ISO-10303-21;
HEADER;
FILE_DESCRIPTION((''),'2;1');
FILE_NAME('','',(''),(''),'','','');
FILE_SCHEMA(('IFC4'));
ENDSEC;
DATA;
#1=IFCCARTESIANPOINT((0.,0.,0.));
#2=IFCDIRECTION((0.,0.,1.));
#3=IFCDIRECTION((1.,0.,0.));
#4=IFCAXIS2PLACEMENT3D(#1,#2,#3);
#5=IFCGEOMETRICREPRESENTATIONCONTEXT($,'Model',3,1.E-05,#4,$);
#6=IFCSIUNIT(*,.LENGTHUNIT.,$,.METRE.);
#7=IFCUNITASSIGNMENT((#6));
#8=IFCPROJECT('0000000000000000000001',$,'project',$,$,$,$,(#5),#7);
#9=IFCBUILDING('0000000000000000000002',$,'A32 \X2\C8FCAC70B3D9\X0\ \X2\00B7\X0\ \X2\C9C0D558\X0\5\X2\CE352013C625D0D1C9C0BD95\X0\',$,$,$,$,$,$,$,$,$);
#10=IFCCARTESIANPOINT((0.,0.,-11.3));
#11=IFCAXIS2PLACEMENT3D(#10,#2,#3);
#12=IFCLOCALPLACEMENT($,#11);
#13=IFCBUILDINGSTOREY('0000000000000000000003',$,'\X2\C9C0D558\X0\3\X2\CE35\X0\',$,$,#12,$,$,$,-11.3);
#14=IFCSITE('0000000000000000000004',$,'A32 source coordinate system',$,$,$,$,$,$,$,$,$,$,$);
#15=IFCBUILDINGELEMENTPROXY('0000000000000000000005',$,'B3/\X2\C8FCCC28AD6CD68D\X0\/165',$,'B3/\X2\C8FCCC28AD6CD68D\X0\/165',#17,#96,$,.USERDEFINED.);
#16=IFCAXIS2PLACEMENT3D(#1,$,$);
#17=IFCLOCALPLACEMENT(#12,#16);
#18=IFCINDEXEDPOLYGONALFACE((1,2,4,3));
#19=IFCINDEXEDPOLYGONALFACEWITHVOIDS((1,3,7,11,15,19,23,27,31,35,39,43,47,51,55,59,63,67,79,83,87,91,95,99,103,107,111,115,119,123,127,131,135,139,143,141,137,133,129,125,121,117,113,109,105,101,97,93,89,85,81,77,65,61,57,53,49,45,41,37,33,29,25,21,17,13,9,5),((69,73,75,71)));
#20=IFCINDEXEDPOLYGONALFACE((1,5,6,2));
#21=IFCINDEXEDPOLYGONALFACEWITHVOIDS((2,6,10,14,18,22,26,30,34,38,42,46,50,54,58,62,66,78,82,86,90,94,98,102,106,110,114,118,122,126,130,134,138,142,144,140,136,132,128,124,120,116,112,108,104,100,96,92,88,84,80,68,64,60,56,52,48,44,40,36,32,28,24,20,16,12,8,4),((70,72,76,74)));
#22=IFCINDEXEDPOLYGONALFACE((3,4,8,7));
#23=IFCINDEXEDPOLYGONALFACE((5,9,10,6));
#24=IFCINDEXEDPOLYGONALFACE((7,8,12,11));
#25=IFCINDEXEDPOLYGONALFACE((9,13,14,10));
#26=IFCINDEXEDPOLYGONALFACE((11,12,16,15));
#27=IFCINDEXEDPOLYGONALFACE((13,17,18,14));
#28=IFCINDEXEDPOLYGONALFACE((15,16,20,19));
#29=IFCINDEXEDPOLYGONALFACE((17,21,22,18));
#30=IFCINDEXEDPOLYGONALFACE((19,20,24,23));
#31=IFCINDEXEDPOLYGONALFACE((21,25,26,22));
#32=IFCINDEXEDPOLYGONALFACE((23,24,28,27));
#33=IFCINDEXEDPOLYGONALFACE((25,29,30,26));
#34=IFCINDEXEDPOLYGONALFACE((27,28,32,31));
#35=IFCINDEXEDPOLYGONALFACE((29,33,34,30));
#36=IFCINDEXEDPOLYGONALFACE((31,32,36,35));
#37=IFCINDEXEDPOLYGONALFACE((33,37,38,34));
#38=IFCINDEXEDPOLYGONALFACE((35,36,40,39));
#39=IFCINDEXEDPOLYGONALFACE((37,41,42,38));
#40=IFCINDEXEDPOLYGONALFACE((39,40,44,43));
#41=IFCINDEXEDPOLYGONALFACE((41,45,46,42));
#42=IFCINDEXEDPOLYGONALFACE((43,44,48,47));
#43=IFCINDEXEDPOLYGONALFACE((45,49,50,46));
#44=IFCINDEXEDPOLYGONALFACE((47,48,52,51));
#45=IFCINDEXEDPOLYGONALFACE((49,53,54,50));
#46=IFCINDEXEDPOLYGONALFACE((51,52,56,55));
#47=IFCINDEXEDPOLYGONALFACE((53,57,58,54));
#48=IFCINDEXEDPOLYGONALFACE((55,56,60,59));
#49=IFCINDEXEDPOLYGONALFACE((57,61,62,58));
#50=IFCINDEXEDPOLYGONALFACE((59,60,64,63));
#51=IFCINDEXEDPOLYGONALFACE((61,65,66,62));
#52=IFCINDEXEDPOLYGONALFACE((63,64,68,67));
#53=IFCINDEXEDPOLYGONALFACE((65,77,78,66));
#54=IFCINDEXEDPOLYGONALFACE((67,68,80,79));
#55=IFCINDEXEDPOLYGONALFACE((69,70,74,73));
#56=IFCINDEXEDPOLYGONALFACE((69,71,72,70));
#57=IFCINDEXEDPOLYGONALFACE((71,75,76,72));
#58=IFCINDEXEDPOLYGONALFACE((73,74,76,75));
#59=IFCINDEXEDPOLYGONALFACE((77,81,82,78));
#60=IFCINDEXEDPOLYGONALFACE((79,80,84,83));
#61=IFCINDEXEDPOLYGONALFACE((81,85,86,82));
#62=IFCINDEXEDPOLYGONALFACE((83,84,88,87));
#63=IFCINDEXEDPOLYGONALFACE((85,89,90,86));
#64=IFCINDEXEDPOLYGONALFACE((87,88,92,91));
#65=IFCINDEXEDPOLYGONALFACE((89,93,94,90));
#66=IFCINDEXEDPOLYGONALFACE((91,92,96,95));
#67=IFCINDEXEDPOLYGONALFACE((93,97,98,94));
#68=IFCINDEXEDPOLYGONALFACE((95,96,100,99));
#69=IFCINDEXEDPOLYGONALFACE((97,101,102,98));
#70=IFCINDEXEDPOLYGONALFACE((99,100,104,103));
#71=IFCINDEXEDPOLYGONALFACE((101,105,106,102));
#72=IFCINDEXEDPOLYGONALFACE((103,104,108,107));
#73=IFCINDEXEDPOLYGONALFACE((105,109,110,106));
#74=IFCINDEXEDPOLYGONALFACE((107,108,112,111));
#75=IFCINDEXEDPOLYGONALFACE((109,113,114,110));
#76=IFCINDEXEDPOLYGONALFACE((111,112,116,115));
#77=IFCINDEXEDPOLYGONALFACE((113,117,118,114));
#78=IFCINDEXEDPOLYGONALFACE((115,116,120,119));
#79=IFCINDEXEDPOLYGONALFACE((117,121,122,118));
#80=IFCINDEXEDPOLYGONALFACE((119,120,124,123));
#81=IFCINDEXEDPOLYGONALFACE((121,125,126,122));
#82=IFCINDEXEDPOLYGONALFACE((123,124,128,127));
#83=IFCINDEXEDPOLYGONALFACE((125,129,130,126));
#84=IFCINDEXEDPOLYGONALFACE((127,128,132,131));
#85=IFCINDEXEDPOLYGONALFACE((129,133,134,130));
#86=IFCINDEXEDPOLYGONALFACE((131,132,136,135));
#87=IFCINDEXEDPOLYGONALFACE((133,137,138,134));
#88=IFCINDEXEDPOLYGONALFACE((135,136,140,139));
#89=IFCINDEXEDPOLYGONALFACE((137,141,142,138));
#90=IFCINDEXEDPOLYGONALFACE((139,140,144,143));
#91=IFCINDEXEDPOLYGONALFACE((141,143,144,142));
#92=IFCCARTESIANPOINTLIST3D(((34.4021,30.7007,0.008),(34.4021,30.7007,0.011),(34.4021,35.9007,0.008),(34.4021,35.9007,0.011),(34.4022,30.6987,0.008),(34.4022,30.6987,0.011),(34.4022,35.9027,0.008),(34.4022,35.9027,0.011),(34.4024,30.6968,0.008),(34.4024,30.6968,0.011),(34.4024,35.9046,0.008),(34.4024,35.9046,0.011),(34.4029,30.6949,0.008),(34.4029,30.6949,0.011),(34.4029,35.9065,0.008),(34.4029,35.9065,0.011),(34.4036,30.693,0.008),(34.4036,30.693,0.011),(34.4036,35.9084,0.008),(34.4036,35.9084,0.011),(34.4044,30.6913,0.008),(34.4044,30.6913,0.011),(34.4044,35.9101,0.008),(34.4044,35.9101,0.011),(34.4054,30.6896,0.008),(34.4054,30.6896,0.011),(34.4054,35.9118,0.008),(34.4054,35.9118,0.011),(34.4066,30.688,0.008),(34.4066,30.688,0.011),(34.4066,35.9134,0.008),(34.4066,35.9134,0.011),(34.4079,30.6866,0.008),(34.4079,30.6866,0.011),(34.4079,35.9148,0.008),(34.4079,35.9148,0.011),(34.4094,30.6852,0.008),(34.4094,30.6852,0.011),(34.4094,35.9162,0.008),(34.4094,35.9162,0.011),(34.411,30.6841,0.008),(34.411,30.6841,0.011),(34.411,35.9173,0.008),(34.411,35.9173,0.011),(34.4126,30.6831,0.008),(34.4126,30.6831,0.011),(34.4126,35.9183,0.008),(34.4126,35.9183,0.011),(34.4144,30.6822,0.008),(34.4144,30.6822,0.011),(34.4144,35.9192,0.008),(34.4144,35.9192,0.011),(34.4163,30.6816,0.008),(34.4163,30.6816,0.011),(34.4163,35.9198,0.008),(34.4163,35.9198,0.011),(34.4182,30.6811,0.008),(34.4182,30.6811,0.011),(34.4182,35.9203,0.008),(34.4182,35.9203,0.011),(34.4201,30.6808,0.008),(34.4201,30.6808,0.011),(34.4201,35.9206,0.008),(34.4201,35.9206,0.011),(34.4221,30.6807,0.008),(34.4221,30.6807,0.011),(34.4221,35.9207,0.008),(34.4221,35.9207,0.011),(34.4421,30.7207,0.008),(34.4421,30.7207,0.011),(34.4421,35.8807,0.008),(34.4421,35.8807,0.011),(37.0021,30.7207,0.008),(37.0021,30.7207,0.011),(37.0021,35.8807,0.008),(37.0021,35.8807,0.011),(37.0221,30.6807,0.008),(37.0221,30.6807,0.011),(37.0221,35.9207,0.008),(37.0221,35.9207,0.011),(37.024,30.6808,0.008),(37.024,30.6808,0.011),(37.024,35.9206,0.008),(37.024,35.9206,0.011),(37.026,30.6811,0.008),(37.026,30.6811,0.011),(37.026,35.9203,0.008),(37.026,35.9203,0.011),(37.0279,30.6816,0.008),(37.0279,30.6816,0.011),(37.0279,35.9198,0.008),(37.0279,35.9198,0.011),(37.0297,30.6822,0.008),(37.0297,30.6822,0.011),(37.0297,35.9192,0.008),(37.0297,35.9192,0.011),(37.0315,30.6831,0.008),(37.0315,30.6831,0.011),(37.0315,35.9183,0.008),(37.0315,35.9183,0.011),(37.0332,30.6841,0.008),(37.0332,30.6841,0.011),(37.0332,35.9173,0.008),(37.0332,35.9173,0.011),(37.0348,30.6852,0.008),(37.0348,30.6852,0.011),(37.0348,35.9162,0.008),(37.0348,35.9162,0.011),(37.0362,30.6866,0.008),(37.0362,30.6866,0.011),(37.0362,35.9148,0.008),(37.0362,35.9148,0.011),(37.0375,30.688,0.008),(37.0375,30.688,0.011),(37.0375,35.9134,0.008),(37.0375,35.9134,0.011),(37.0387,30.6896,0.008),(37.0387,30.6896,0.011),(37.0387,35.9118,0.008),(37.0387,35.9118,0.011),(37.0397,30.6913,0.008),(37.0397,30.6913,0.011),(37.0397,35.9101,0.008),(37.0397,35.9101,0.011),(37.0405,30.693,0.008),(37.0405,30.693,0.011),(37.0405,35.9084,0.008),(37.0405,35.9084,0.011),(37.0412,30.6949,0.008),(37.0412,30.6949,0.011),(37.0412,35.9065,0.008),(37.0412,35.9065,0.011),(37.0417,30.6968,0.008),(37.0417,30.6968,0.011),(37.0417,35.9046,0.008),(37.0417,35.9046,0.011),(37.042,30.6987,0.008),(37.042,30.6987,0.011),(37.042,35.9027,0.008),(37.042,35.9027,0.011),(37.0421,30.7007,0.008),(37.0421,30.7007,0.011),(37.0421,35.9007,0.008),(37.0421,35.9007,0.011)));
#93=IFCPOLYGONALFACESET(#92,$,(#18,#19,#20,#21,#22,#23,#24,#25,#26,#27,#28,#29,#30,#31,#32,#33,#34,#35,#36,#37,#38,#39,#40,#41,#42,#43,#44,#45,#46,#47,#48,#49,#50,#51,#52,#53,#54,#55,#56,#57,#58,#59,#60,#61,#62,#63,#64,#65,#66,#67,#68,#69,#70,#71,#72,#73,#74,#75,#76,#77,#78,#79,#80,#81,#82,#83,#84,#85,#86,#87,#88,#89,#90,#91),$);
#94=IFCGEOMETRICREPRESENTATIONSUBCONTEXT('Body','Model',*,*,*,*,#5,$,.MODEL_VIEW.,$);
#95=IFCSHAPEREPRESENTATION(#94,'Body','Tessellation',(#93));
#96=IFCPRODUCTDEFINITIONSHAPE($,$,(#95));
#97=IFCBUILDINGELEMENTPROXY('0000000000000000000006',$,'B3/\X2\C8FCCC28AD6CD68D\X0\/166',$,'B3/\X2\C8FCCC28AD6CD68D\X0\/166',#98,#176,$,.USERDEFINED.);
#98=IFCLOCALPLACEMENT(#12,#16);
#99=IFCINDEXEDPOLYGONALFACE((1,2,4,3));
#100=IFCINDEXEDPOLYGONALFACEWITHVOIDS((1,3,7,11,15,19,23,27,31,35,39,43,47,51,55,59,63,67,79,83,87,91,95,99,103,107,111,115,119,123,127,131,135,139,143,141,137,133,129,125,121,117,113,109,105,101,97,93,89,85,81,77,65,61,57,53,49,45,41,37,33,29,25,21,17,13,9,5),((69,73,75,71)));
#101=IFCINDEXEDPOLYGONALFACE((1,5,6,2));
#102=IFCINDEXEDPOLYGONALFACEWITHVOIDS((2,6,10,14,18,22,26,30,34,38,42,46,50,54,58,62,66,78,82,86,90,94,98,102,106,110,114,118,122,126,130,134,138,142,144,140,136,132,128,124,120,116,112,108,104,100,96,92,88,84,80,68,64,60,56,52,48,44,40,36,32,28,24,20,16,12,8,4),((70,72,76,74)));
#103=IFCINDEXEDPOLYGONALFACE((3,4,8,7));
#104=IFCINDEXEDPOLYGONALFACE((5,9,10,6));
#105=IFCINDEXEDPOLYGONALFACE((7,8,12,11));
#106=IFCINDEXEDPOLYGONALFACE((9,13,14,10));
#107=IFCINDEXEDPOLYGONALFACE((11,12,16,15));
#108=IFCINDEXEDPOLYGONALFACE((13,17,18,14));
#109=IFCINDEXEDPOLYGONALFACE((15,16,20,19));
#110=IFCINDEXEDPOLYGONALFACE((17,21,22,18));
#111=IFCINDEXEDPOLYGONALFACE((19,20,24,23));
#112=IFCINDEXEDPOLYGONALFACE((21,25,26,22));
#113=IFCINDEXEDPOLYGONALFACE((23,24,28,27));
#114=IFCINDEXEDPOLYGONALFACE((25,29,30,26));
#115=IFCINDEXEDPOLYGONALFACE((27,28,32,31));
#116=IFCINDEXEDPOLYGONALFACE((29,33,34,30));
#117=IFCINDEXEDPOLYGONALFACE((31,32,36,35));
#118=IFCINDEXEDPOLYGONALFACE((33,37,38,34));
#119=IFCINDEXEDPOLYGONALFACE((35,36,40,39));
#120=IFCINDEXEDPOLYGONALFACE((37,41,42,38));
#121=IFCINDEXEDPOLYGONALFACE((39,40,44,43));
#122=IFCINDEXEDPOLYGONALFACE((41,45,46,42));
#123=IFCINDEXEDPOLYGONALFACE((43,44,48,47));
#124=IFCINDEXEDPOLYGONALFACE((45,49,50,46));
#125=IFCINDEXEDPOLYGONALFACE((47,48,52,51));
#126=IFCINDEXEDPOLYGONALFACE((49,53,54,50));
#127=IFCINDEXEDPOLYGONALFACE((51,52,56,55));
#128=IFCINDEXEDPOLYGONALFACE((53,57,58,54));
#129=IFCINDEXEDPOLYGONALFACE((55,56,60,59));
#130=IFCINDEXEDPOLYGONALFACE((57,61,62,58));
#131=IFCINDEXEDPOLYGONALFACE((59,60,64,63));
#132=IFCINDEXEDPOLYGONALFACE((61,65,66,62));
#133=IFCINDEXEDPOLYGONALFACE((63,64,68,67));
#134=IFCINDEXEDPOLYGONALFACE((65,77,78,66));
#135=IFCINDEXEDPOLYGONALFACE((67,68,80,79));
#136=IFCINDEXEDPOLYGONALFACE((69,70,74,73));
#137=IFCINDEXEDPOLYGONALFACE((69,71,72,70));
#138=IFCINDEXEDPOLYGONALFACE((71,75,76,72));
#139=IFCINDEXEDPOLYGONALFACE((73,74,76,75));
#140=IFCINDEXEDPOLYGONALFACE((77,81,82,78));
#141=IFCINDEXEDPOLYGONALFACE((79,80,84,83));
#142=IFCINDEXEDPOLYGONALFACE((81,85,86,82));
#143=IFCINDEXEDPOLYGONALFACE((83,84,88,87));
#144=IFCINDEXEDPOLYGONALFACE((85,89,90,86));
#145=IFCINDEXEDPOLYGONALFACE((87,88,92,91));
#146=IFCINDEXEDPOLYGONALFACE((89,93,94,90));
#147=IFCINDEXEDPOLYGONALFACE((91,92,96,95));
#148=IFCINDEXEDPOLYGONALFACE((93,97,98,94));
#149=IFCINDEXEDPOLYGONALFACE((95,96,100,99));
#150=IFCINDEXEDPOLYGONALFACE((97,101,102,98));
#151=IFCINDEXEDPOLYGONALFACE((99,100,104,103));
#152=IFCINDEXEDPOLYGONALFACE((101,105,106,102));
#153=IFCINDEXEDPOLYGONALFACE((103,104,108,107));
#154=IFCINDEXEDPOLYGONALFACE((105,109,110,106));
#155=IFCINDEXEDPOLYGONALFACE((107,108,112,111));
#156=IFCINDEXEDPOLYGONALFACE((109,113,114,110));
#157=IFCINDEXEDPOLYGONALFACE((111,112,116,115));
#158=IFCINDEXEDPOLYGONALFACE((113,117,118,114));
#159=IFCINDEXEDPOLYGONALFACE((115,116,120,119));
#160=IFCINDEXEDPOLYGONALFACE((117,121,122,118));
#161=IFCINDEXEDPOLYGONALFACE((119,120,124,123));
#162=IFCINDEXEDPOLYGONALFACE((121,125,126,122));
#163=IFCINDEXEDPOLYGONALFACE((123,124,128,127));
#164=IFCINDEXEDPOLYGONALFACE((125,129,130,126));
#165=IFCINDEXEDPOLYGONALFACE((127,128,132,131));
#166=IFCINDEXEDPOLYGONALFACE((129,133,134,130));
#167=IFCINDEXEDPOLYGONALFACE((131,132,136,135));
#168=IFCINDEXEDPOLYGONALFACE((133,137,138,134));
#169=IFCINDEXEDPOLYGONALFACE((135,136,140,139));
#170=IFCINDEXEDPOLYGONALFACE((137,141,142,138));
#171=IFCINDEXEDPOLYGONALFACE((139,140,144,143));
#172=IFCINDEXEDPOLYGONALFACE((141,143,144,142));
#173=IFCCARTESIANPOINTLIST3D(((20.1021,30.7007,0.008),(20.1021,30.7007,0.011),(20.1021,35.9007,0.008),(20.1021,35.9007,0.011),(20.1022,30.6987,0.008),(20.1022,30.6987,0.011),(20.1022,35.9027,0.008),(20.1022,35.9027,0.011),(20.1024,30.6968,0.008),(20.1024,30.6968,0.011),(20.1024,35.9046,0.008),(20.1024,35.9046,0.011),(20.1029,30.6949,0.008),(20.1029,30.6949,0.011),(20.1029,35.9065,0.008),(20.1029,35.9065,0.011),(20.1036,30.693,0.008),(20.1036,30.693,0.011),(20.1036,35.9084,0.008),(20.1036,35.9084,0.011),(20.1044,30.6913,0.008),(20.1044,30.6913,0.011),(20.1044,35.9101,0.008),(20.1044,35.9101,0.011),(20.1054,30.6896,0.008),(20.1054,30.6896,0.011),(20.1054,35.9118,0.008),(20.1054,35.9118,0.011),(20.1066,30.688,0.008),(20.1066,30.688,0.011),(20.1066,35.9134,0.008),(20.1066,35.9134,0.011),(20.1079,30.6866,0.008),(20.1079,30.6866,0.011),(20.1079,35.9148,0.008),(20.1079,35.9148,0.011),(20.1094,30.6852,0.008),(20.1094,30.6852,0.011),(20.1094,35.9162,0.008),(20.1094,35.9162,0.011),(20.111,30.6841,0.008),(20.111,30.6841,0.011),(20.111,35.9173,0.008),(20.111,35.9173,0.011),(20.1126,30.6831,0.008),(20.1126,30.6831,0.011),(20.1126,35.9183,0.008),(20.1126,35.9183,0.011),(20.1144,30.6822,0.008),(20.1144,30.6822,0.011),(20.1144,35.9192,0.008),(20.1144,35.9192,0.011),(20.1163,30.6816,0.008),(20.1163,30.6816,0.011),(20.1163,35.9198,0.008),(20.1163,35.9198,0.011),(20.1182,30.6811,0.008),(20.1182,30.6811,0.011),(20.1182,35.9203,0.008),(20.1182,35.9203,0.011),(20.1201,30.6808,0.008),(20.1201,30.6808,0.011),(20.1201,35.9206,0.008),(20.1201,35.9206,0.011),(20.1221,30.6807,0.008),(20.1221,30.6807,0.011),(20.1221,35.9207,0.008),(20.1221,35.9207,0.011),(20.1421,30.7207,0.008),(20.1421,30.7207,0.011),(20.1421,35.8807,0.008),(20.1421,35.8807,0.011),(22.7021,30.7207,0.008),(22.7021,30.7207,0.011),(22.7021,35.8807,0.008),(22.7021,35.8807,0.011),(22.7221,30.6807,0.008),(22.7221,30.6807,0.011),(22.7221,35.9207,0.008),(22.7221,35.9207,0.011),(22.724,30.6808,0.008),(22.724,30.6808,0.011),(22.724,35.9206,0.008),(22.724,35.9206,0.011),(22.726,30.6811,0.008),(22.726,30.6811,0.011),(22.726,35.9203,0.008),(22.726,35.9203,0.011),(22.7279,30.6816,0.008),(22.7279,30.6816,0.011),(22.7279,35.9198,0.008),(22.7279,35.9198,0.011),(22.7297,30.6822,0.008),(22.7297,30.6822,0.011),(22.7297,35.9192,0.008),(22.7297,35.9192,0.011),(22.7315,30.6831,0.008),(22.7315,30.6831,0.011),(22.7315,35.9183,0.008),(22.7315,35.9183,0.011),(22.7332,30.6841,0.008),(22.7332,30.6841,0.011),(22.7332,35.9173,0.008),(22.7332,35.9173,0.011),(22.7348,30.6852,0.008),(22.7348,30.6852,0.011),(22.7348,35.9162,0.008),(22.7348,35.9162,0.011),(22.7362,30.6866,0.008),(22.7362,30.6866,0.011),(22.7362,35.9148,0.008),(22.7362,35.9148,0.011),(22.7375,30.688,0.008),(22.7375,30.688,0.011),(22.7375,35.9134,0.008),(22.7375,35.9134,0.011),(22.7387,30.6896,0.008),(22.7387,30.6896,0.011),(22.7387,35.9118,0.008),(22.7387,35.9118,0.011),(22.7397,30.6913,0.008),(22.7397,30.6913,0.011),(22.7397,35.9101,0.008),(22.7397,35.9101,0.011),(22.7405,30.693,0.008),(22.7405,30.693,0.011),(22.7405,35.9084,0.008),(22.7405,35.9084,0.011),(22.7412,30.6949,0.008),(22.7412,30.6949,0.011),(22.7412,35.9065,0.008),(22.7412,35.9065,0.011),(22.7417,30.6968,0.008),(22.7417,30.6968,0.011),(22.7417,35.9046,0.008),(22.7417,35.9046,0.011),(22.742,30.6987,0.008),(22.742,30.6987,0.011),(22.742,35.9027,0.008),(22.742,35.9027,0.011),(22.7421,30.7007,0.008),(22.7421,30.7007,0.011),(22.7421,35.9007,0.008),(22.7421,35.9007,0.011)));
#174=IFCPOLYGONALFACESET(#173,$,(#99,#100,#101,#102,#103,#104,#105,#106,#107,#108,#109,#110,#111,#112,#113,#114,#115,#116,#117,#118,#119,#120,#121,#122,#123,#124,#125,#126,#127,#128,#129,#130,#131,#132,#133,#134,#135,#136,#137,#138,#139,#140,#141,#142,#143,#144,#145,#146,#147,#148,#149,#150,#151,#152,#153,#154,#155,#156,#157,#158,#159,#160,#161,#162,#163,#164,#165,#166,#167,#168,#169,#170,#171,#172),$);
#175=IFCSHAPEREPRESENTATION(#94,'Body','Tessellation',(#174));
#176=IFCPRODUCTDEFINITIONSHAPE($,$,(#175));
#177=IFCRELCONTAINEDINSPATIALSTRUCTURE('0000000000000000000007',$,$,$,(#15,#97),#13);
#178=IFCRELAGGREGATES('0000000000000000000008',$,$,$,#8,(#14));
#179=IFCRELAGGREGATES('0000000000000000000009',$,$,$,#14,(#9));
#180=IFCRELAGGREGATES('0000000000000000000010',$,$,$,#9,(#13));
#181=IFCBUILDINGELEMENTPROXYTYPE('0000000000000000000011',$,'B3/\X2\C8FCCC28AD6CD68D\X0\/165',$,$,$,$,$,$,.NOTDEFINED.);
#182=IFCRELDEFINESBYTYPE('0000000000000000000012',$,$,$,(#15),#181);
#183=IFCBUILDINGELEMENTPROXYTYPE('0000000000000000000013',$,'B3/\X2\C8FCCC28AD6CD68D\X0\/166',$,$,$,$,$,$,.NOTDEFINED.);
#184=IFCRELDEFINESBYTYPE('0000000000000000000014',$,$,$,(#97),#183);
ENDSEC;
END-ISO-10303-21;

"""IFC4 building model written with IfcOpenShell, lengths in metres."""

from ifc_helpers import new_model, si_unit, frame, origin, origin_with_axes, place, context, subcontext, project, spatial, polyline, outline, extrude, source, transform, mapped, type_object, type_shapes, element, save


model = new_model("IFC4")

# Units and contexts
model_context = context("Model", 3, precision=1e-05, world=origin_with_axes())
body_context = subcontext(model_context, "Body", "Model", "MODEL_VIEW")
ifc_project = project(units=[si_unit("LENGTHUNIT", "METRE")], contexts=[model_context])

# Site, building, storey
site = spatial("IfcSite", under=ifc_project, Name="A32 source coordinate system")
building = spatial("IfcBuilding", under=site, Name="A32 주거동 · 지하5층–옥탑지붕")
storey_placement = place(None, frame((0.0, 0.0, -11.3), z_axis=(0.0, 0.0, 1.0), x_axis=(1.0, 0.0, 0.0)))
storey = spatial("IfcBuildingStorey", under=building, at=storey_placement, Name="지하3층", Elevation=-11.3)

# Building element proxies
building_element_proxy_type_1 = type_object("IfcBuildingElementProxyType", Name="B3/주차구획/165", PredefinedType="NOTDEFINED")
shared_shape_1 = source(origin(), body_context, "Body", "SweptSolid", [
    extrude(outline(polyline([(34.4021, 35.9007), (34.4022, 35.9027), (34.4024, 35.9046), (34.4029, 35.9065), (34.4036, 35.9084), (34.4044, 35.9101), (34.4054, 35.9118), (34.4066, 35.9134), (34.4079, 35.9148), (34.4094, 35.9162), (34.411, 35.9173), (34.4126, 35.9183), (34.4144, 35.9192), (34.4163, 35.9198), (34.4182, 35.9203), (34.4201, 35.9206), (34.4221, 35.9207), (37.0221, 35.9207), (37.024, 35.9206), (37.026, 35.9203), (37.0279, 35.9198), (37.0297, 35.9192), (37.0315, 35.9183), (37.0332, 35.9173), (37.0348, 35.9162), (37.0362, 35.9148), (37.0375, 35.9134), (37.0387, 35.9118), (37.0397, 35.9101), (37.0405, 35.9084), (37.0412, 35.9065), (37.0417, 35.9046), (37.042, 35.9027), (37.0421, 35.9007), (37.0421, 30.7007), (37.042, 30.6987), (37.0417, 30.6968), (37.0412, 30.6949), (37.0405, 30.693), (37.0397, 30.6913), (37.0387, 30.6896), (37.0375, 30.688), (37.0362, 30.6866), (37.0348, 30.6852), (37.0332, 30.6841), (37.0315, 30.6831), (37.0297, 30.6822), (37.0279, 30.6816), (37.026, 30.6811), (37.024, 30.6808), (37.0221, 30.6807), (34.4221, 30.6807), (34.4201, 30.6808), (34.4182, 30.6811), (34.4163, 30.6816), (34.4144, 30.6822), (34.4126, 30.6831), (34.411, 30.6841), (34.4094, 30.6852), (34.4079, 30.6866), (34.4066, 30.688), (34.4054, 30.6896), (34.4044, 30.6913), (34.4036, 30.693), (34.4029, 30.6949), (34.4024, 30.6968), (34.4022, 30.6987), (34.4021, 30.7007), (34.4021, 35.9007)]), holes=[polyline([(34.4421, 35.8807), (34.4421, 30.7207), (37.0021, 30.7207), (37.0021, 35.8807), (34.4421, 35.8807)])]), frame((0.0, 0.0, 0.008)), (0.0, 0.0, 1.0), 0.003),
])
type_shapes(building_element_proxy_type_1, [shared_shape_1])
proxy_1_placement = place(storey_placement, origin_with_axes())
element("IfcBuildingElementProxy", 1, at=proxy_1_placement, inside=storey, type_object=building_element_proxy_type_1, Name="B3/주차구획/165", ObjectType="B3/주차구획/165", PredefinedType="USERDEFINED", context=body_context, shape_type="MappedRepresentation", body=[
    mapped(shared_shape_1, transform((0.0, 0.0, 0.0), scale=1.0)),
])
building_element_proxy_type_2 = type_object("IfcBuildingElementProxyType", Name="B3/주차구획/166", PredefinedType="NOTDEFINED")
shared_shape_2 = source(origin(), body_context, "Body", "SweptSolid", [
    extrude(outline(polyline([(20.1021, 35.9007), (20.1022, 35.9027), (20.1024, 35.9046), (20.1029, 35.9065), (20.1036, 35.9084), (20.1044, 35.9101), (20.1054, 35.9118), (20.1066, 35.9134), (20.1079, 35.9148), (20.1094, 35.9162), (20.111, 35.9173), (20.1126, 35.9183), (20.1144, 35.9192), (20.1163, 35.9198), (20.1182, 35.9203), (20.1201, 35.9206), (20.1221, 35.9207), (22.7221, 35.9207), (22.724, 35.9206), (22.726, 35.9203), (22.7279, 35.9198), (22.7297, 35.9192), (22.7315, 35.9183), (22.7332, 35.9173), (22.7348, 35.9162), (22.7362, 35.9148), (22.7375, 35.9134), (22.7387, 35.9118), (22.7397, 35.9101), (22.7405, 35.9084), (22.7412, 35.9065), (22.7417, 35.9046), (22.742, 35.9027), (22.7421, 35.9007), (22.7421, 30.7007), (22.742, 30.6987), (22.7417, 30.6968), (22.7412, 30.6949), (22.7405, 30.693), (22.7397, 30.6913), (22.7387, 30.6896), (22.7375, 30.688), (22.7362, 30.6866), (22.7348, 30.6852), (22.7332, 30.6841), (22.7315, 30.6831), (22.7297, 30.6822), (22.7279, 30.6816), (22.726, 30.6811), (22.724, 30.6808), (22.7221, 30.6807), (20.1221, 30.6807), (20.1201, 30.6808), (20.1182, 30.6811), (20.1163, 30.6816), (20.1144, 30.6822), (20.1126, 30.6831), (20.111, 30.6841), (20.1094, 30.6852), (20.1079, 30.6866), (20.1066, 30.688), (20.1054, 30.6896), (20.1044, 30.6913), (20.1036, 30.693), (20.1029, 30.6949), (20.1024, 30.6968), (20.1022, 30.6987), (20.1021, 30.7007), (20.1021, 35.9007)]), holes=[polyline([(20.1421, 35.8807), (20.1421, 30.7207), (22.7021, 30.7207), (22.7021, 35.8807), (20.1421, 35.8807)])]), frame((0.0, 0.0, 0.008)), (0.0, 0.0, 1.0), 0.003),
])
type_shapes(building_element_proxy_type_2, [shared_shape_2])
proxy_2_placement = place(storey_placement, origin_with_axes())
element("IfcBuildingElementProxy", 2, at=proxy_2_placement, inside=storey, type_object=building_element_proxy_type_2, Name="B3/주차구획/166", ObjectType="B3/주차구획/166", PredefinedType="USERDEFINED", context=body_context, shape_type="MappedRepresentation", body=[
    mapped(shared_shape_2, transform((0.0, 0.0, 0.0), scale=1.0)),
])

save(model, "model.ifc")
